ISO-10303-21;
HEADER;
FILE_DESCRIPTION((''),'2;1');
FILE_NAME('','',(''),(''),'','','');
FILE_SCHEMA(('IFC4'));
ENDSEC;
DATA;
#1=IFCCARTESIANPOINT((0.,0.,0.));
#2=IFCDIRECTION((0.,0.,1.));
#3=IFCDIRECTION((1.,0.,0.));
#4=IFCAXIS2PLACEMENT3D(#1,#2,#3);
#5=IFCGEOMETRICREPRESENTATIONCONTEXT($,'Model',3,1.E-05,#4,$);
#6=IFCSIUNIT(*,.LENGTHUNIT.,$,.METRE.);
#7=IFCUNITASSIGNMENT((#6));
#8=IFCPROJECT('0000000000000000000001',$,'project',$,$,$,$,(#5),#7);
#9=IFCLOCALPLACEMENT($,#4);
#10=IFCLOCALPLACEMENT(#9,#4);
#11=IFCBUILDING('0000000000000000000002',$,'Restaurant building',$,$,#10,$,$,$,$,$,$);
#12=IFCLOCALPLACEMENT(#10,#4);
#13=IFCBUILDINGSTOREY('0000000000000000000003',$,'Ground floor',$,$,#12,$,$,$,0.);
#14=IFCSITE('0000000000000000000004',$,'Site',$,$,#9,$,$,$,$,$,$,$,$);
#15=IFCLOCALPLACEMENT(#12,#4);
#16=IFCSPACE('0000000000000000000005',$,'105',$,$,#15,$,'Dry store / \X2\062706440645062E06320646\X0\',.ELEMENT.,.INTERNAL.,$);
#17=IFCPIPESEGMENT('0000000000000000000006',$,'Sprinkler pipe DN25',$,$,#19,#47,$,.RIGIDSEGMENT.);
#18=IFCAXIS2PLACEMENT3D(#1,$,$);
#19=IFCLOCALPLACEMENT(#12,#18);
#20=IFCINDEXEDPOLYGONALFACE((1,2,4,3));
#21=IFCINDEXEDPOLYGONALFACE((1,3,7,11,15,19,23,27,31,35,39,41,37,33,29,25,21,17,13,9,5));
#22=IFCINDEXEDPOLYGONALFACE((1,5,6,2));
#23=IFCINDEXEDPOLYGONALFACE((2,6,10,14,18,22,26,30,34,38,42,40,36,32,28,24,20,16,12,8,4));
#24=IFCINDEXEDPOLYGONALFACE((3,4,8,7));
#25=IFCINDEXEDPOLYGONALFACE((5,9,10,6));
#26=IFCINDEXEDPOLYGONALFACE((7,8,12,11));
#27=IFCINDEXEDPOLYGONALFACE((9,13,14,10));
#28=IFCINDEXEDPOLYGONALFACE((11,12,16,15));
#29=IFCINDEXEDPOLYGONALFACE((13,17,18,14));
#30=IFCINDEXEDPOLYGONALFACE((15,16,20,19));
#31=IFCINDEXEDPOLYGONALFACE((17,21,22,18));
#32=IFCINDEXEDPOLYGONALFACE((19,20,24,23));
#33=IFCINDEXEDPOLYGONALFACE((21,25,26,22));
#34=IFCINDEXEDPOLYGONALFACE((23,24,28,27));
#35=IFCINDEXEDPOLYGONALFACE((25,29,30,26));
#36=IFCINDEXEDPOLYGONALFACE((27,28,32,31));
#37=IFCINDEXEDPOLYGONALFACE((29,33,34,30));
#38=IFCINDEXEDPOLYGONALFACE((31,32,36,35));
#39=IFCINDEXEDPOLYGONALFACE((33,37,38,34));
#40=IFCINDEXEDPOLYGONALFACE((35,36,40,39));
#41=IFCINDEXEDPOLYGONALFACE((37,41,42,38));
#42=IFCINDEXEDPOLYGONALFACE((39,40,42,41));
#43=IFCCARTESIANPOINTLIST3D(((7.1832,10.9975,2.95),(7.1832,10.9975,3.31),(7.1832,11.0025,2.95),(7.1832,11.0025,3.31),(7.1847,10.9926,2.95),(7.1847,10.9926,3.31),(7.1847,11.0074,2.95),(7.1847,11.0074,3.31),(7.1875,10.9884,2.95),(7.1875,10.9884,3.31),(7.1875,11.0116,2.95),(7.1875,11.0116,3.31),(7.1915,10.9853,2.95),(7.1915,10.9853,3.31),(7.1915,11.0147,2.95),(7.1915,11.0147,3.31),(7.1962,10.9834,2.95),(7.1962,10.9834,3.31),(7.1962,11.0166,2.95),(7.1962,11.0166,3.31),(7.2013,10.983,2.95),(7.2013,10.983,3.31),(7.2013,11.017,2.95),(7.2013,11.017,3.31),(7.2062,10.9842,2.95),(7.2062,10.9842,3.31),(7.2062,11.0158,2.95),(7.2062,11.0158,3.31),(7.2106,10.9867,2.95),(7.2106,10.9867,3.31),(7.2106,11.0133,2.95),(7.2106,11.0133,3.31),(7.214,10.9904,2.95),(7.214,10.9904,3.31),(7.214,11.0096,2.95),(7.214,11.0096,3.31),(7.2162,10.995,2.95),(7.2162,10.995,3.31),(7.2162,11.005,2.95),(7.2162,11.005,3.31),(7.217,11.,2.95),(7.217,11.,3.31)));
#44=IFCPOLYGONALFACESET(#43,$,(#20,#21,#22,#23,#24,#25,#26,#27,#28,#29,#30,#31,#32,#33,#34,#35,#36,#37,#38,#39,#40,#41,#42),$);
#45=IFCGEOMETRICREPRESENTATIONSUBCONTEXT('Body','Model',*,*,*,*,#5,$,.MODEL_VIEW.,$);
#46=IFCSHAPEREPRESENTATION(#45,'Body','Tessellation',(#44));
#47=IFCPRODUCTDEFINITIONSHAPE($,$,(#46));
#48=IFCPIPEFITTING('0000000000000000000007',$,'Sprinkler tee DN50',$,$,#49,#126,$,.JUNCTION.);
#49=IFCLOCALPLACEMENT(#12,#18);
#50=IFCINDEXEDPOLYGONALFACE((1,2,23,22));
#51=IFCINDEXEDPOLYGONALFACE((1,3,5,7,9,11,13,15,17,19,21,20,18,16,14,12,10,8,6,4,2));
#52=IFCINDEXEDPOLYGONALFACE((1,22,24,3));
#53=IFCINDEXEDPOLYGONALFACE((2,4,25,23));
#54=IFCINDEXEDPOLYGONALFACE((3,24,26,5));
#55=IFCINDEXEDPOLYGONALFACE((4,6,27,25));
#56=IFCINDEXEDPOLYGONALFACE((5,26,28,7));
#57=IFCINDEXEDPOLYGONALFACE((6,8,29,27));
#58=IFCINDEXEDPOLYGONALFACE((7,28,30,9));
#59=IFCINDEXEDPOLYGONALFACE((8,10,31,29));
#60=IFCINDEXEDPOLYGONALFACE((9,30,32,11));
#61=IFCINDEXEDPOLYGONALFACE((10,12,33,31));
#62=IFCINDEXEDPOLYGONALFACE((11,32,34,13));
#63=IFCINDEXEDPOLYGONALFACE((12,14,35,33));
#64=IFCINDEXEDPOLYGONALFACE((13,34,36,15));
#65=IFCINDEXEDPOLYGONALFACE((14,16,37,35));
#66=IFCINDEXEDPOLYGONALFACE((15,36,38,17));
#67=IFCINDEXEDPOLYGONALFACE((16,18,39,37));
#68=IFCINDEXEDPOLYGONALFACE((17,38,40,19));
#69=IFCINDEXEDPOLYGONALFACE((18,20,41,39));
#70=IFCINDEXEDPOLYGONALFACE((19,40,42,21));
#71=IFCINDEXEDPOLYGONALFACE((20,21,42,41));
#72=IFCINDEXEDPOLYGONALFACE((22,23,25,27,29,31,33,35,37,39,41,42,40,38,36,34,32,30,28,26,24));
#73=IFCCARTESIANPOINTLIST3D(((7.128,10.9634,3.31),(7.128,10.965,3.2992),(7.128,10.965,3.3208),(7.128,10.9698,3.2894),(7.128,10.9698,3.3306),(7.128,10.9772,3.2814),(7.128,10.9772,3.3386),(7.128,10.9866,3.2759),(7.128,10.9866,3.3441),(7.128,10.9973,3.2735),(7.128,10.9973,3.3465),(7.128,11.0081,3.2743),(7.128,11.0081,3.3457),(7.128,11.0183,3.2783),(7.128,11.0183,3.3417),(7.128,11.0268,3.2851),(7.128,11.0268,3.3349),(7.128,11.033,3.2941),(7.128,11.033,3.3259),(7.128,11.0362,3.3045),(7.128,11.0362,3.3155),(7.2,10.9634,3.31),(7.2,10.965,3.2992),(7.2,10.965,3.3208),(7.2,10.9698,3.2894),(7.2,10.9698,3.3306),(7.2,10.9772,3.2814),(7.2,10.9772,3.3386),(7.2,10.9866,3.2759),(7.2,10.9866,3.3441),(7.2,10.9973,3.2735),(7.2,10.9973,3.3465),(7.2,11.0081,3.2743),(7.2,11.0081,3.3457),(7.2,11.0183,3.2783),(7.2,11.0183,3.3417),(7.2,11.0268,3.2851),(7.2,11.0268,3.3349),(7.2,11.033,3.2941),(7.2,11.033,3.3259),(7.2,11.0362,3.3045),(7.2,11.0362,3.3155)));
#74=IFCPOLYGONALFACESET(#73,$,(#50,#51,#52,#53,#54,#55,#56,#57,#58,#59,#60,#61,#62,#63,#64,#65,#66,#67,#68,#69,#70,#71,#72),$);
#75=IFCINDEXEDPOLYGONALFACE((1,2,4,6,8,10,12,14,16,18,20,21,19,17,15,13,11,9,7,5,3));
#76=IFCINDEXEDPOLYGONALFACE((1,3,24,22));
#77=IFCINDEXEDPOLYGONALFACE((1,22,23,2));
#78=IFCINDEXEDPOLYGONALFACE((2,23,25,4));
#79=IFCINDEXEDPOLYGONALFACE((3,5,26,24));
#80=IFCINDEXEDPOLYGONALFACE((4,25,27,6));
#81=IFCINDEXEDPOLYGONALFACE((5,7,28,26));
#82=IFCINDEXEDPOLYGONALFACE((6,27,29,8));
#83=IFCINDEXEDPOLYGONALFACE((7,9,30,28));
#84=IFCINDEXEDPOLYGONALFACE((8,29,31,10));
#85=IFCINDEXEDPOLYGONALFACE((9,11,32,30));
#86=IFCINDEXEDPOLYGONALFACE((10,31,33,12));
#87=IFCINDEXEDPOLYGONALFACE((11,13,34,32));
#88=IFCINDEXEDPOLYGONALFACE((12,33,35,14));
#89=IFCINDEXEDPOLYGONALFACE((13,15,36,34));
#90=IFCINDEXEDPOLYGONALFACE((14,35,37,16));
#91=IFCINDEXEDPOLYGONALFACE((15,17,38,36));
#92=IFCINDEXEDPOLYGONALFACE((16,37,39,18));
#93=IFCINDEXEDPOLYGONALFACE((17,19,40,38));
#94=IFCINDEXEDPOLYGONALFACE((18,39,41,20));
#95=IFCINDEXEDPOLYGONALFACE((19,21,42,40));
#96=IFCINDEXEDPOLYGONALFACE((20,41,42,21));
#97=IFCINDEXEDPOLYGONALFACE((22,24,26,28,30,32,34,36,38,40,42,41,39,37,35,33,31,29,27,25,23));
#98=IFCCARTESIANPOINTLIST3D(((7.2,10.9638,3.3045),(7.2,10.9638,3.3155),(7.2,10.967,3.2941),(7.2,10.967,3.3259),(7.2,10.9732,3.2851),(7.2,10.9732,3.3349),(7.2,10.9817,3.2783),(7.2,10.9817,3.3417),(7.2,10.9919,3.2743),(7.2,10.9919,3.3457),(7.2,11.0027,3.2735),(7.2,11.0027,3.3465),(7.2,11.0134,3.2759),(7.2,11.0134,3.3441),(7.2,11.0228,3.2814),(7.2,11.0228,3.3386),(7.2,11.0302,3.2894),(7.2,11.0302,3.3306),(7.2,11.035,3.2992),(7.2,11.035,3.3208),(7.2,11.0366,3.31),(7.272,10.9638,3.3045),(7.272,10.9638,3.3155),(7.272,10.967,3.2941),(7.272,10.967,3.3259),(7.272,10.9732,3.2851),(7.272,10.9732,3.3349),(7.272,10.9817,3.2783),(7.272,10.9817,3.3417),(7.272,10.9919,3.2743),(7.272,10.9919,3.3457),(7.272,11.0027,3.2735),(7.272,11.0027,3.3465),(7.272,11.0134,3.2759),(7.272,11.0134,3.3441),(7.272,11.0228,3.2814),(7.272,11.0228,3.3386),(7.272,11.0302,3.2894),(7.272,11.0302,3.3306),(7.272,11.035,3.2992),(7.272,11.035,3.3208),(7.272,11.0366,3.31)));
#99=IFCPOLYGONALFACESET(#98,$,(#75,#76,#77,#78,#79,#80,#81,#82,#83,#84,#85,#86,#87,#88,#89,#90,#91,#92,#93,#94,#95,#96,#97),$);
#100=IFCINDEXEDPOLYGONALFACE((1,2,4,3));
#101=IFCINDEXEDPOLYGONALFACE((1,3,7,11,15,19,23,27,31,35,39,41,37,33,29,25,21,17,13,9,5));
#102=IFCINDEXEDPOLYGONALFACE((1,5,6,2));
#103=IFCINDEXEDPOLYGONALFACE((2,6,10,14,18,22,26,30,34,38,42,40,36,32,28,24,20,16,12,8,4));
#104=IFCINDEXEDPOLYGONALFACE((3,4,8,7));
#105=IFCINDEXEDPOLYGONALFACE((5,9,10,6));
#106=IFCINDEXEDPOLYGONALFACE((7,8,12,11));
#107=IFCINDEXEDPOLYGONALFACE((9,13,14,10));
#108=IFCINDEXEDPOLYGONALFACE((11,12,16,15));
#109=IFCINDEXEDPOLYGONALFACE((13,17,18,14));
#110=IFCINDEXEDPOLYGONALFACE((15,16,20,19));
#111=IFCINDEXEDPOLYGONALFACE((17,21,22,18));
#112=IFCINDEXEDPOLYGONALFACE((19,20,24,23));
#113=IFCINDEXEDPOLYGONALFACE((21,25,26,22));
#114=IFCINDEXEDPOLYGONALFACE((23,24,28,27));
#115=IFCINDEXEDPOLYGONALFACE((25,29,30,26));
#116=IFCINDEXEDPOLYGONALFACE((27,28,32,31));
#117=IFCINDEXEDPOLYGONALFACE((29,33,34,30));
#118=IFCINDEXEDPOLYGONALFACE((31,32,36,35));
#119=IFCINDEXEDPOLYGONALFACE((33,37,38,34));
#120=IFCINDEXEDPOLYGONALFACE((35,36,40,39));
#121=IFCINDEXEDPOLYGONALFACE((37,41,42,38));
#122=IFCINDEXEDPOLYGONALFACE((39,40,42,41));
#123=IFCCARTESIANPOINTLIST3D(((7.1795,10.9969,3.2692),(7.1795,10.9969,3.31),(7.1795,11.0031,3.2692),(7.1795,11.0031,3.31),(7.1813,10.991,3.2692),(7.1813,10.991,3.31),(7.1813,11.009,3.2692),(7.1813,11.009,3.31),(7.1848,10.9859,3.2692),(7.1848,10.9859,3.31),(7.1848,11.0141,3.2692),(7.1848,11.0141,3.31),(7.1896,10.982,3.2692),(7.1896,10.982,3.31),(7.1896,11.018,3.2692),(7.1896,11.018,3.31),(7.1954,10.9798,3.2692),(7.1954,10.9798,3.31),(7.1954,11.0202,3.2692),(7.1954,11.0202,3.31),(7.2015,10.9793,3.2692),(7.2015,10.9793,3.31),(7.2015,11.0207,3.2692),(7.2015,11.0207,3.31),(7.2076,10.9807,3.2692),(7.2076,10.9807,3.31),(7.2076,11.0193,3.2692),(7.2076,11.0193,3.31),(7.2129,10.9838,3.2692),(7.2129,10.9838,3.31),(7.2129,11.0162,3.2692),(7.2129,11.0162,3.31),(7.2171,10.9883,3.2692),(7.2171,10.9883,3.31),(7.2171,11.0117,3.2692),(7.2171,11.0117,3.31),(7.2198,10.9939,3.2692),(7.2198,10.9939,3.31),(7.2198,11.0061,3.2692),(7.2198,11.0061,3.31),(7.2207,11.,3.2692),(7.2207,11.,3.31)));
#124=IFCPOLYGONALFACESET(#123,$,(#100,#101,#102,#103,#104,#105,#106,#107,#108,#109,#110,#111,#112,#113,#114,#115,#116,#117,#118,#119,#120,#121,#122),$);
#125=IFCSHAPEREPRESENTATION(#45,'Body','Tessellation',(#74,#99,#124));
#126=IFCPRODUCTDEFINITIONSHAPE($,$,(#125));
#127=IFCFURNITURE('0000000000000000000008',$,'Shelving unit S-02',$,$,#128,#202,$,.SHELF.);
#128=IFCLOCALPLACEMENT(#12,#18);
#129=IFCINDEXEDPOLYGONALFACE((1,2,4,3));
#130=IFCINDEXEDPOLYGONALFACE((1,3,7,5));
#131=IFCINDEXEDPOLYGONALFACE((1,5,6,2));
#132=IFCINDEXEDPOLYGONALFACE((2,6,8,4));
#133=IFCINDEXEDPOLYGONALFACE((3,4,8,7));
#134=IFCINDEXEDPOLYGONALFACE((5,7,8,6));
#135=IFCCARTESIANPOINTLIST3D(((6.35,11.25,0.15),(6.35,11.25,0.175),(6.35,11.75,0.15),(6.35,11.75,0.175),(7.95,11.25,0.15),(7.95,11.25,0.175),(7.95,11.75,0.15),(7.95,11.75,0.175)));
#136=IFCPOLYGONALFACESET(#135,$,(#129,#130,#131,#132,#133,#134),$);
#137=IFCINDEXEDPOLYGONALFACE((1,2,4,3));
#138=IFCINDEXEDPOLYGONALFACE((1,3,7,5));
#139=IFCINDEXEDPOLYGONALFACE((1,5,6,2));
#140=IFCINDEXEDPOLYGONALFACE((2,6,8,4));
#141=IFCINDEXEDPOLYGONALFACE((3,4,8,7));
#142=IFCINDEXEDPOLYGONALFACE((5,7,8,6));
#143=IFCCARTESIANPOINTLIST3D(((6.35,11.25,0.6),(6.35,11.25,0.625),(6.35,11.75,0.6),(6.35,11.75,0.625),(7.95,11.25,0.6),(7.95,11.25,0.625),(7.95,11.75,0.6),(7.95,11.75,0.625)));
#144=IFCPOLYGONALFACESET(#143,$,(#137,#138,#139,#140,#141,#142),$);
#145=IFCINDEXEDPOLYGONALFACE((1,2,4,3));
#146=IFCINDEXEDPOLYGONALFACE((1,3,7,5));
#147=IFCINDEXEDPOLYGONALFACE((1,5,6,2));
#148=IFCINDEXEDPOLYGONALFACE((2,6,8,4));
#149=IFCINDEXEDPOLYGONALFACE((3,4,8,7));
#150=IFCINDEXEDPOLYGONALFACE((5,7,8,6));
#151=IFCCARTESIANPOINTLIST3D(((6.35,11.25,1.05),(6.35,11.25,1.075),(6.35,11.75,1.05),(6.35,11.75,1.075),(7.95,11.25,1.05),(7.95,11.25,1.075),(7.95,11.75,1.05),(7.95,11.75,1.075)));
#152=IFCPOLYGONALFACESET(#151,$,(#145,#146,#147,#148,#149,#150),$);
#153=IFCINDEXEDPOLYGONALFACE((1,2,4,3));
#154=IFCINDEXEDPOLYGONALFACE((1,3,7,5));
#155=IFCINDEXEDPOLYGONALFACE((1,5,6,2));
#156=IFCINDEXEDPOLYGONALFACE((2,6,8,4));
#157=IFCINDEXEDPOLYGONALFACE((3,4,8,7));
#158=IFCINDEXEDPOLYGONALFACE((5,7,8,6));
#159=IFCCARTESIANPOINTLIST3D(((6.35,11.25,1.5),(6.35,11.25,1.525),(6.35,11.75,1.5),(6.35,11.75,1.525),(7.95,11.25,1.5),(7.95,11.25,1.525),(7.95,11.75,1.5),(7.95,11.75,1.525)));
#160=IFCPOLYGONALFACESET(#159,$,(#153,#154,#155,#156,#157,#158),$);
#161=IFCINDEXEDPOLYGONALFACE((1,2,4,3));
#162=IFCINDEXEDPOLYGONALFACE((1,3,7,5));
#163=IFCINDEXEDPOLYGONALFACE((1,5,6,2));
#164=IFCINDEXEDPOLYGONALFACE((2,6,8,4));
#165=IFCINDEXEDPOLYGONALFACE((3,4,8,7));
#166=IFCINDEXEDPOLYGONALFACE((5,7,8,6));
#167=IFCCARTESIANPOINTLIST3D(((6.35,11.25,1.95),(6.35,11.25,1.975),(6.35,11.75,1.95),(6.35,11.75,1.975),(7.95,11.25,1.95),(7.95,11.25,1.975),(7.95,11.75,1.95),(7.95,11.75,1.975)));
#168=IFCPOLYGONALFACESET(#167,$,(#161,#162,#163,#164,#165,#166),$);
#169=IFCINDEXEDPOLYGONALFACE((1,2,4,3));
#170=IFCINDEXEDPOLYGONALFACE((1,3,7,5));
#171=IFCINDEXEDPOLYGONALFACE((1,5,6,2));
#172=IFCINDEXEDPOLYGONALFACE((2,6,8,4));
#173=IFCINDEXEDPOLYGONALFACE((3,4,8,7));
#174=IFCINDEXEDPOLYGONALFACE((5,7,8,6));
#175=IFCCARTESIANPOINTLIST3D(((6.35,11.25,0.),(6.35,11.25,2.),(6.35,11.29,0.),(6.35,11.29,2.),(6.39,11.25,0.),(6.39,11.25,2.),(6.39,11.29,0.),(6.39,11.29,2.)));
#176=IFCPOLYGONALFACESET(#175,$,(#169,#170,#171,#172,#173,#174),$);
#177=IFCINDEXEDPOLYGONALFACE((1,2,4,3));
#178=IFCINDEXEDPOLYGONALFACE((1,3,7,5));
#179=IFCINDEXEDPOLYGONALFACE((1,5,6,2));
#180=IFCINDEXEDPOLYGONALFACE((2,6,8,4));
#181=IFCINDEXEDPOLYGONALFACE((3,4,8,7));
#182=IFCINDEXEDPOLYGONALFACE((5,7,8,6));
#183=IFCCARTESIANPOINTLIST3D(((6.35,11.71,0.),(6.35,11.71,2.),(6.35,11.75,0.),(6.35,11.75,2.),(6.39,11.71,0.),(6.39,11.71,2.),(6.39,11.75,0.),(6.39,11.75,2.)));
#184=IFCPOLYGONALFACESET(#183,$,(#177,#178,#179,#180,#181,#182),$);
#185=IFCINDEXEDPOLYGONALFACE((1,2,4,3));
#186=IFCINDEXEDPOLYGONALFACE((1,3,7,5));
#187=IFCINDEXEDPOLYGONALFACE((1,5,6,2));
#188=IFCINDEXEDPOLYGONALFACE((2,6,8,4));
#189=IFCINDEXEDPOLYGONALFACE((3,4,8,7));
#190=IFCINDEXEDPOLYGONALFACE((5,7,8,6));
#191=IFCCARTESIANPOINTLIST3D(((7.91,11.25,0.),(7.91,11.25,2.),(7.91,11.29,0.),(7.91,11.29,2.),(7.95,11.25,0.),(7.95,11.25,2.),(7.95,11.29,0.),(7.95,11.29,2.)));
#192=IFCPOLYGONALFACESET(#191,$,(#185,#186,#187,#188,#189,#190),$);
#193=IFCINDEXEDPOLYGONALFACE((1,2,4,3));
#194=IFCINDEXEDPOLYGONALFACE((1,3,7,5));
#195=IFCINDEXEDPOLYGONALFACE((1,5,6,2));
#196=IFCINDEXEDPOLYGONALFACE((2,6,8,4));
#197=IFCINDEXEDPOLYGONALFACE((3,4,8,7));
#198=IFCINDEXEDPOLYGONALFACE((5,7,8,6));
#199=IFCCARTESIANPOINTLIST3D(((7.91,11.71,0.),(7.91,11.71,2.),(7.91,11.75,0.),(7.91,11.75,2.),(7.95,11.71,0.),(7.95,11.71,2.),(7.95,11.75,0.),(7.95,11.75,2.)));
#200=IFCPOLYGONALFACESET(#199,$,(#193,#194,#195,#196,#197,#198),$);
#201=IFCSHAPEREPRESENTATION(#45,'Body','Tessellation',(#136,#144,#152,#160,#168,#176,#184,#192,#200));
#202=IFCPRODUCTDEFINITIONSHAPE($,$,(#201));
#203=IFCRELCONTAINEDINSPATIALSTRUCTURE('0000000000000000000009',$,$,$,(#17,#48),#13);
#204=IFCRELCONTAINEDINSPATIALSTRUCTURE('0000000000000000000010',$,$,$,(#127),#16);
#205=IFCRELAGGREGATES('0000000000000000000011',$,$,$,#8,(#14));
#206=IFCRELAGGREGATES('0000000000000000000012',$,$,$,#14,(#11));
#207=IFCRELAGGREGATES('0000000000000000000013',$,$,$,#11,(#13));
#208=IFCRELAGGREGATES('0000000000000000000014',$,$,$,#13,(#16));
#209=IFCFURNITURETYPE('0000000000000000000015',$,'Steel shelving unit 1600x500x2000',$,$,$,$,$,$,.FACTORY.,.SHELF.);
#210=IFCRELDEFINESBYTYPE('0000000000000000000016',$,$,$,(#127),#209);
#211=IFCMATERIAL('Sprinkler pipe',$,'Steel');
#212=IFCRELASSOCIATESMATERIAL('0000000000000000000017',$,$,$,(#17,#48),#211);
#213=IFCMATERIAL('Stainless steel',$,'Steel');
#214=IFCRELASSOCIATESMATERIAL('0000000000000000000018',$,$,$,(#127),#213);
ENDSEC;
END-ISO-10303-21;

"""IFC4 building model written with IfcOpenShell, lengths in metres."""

from ifc_helpers import new_model, si_unit, frame, origin, origin_with_axes, origin_2d, place, context, subcontext, project, spatial, rectangle, circle, extrude, source, transform, mapped, material, type_object, type_shapes, element, save


model = new_model("IFC4")

# Units and contexts
model_context = context("Model", 3, precision=1e-05, world=origin_with_axes())
body_context = subcontext(model_context, "Body", "Model", "MODEL_VIEW")
ifc_project = project(units=[si_unit("LENGTHUNIT", "METRE")], contexts=[model_context])

# Site, building, storey
site_placement = place(None, origin_with_axes())
site = spatial("IfcSite", under=ifc_project, at=site_placement, Name="Site")
building_placement = place(site_placement, origin_with_axes())
building = spatial("IfcBuilding", under=site, at=building_placement, Name="Restaurant building")
storey_placement = place(building_placement, origin_with_axes())
storey = spatial("IfcBuildingStorey", under=building, at=storey_placement, Name="Ground floor", Elevation=0.0)

# Pipe segment
ifc_material_1 = material(Name="Sprinkler pipe", Category="Steel")
pipe_segment_1_placement = place(storey_placement, frame((7.2, 11.0, 3.31)))
element("IfcPipeSegment", 1, at=pipe_segment_1_placement, inside=storey, material=ifc_material_1, Name="Sprinkler pipe DN25", PredefinedType="RIGIDSEGMENT", context=body_context, shape_type="SweptSolid", body=[
    extrude(circle(Radius=0.017, at=origin_2d()), frame((0.0, 0.0, 0.0), z_axis=(0.0, 0.0, -1.0), x_axis=(1.0, 0.0, 0.0)), (0.0, 0.0, 1.0), 0.36),
])

# Pipe fitting
pipe_fitting_1_placement = place(storey_placement, frame((7.2, 11.0, 3.31)))
element("IfcPipeFitting", 2, at=pipe_fitting_1_placement, inside=storey, material=ifc_material_1, Name="Sprinkler tee DN50", PredefinedType="JUNCTION", context=body_context, shape_type="SweptSolid", body=[
    extrude(circle(Radius=0.0366, at=origin_2d()), frame((0.0, 0.0, 0.0), z_axis=(-1.0, 0.0, 0.0), x_axis=(0.0, -1.0, 0.0)), (0.0, 0.0, 1.0), 0.072),
    extrude(circle(Radius=0.0366, at=origin_2d()), frame((0.0, 0.0, 0.0), z_axis=(1.0, 0.0, 0.0), x_axis=(0.0, 1.0, 0.0)), (0.0, 0.0, 1.0), 0.072),
    extrude(circle(Radius=0.0207, at=origin_2d()), frame((0.0, 0.0, 0.0), z_axis=(0.0, 0.0, -1.0), x_axis=(1.0, 0.0, 0.0)), (0.0, 0.0, 1.0), 0.0408),
])

# Shared definitions
space_1_placement = place(storey_placement, origin_with_axes())
space_1 = spatial("IfcSpace", under=storey, at=space_1_placement, Name="105", LongName="Dry store / المخزن", CompositionType="ELEMENT", PredefinedType="INTERNAL")

# Furniture
ifc_material_2 = material(Name="Stainless steel", Category="Steel")
furniture_type = type_object("IfcFurnitureType", Name="Steel shelving unit 1600x500x2000", AssemblyPlace="FACTORY", PredefinedType="SHELF")
shared_shape = source(origin(), body_context, "Body", "SweptSolid", [
    extrude(rectangle(XDim=1.6, YDim=0.5, at=origin_2d()), frame((0.0, 0.0, 0.15)), (0.0, 0.0, 1.0), 0.025),
    extrude(rectangle(XDim=1.6, YDim=0.5, at=origin_2d()), frame((0.0, 0.0, 0.6)), (0.0, 0.0, 1.0), 0.025),
    extrude(rectangle(XDim=1.6, YDim=0.5, at=origin_2d()), frame((0.0, 0.0, 1.05)), (0.0, 0.0, 1.0), 0.025),
    extrude(rectangle(XDim=1.6, YDim=0.5, at=origin_2d()), frame((0.0, 0.0, 1.5)), (0.0, 0.0, 1.0), 0.025),
    extrude(rectangle(XDim=1.6, YDim=0.5, at=origin_2d()), frame((0.0, 0.0, 1.95)), (0.0, 0.0, 1.0), 0.025),
    extrude(rectangle(XDim=0.04, YDim=0.04, at=origin_2d()), frame((-0.78, -0.23, 0.0)), (0.0, 0.0, 1.0), 2.0),
    extrude(rectangle(XDim=0.04, YDim=0.04, at=origin_2d()), frame((-0.78, 0.23, 0.0)), (0.0, 0.0, 1.0), 2.0),
    extrude(rectangle(XDim=0.04, YDim=0.04, at=origin_2d()), frame((0.78, -0.23, 0.0)), (0.0, 0.0, 1.0), 2.0),
    extrude(rectangle(XDim=0.04, YDim=0.04, at=origin_2d()), frame((0.78, 0.23, 0.0)), (0.0, 0.0, 1.0), 2.0),
])
type_shapes(furniture_type, [shared_shape])
furniture_placement = place(storey_placement, frame((7.15, 11.5, 0.0)))
element("IfcFurniture", 3, at=furniture_placement, inside=space_1, type_object=furniture_type, material=ifc_material_2, Name="Shelving unit S-02", PredefinedType="SHELF", context=body_context, shape_type="MappedRepresentation", body=[
    mapped(shared_shape, transform((0.0, 0.0, 0.0))),
])

save(model, "model.ifc")
